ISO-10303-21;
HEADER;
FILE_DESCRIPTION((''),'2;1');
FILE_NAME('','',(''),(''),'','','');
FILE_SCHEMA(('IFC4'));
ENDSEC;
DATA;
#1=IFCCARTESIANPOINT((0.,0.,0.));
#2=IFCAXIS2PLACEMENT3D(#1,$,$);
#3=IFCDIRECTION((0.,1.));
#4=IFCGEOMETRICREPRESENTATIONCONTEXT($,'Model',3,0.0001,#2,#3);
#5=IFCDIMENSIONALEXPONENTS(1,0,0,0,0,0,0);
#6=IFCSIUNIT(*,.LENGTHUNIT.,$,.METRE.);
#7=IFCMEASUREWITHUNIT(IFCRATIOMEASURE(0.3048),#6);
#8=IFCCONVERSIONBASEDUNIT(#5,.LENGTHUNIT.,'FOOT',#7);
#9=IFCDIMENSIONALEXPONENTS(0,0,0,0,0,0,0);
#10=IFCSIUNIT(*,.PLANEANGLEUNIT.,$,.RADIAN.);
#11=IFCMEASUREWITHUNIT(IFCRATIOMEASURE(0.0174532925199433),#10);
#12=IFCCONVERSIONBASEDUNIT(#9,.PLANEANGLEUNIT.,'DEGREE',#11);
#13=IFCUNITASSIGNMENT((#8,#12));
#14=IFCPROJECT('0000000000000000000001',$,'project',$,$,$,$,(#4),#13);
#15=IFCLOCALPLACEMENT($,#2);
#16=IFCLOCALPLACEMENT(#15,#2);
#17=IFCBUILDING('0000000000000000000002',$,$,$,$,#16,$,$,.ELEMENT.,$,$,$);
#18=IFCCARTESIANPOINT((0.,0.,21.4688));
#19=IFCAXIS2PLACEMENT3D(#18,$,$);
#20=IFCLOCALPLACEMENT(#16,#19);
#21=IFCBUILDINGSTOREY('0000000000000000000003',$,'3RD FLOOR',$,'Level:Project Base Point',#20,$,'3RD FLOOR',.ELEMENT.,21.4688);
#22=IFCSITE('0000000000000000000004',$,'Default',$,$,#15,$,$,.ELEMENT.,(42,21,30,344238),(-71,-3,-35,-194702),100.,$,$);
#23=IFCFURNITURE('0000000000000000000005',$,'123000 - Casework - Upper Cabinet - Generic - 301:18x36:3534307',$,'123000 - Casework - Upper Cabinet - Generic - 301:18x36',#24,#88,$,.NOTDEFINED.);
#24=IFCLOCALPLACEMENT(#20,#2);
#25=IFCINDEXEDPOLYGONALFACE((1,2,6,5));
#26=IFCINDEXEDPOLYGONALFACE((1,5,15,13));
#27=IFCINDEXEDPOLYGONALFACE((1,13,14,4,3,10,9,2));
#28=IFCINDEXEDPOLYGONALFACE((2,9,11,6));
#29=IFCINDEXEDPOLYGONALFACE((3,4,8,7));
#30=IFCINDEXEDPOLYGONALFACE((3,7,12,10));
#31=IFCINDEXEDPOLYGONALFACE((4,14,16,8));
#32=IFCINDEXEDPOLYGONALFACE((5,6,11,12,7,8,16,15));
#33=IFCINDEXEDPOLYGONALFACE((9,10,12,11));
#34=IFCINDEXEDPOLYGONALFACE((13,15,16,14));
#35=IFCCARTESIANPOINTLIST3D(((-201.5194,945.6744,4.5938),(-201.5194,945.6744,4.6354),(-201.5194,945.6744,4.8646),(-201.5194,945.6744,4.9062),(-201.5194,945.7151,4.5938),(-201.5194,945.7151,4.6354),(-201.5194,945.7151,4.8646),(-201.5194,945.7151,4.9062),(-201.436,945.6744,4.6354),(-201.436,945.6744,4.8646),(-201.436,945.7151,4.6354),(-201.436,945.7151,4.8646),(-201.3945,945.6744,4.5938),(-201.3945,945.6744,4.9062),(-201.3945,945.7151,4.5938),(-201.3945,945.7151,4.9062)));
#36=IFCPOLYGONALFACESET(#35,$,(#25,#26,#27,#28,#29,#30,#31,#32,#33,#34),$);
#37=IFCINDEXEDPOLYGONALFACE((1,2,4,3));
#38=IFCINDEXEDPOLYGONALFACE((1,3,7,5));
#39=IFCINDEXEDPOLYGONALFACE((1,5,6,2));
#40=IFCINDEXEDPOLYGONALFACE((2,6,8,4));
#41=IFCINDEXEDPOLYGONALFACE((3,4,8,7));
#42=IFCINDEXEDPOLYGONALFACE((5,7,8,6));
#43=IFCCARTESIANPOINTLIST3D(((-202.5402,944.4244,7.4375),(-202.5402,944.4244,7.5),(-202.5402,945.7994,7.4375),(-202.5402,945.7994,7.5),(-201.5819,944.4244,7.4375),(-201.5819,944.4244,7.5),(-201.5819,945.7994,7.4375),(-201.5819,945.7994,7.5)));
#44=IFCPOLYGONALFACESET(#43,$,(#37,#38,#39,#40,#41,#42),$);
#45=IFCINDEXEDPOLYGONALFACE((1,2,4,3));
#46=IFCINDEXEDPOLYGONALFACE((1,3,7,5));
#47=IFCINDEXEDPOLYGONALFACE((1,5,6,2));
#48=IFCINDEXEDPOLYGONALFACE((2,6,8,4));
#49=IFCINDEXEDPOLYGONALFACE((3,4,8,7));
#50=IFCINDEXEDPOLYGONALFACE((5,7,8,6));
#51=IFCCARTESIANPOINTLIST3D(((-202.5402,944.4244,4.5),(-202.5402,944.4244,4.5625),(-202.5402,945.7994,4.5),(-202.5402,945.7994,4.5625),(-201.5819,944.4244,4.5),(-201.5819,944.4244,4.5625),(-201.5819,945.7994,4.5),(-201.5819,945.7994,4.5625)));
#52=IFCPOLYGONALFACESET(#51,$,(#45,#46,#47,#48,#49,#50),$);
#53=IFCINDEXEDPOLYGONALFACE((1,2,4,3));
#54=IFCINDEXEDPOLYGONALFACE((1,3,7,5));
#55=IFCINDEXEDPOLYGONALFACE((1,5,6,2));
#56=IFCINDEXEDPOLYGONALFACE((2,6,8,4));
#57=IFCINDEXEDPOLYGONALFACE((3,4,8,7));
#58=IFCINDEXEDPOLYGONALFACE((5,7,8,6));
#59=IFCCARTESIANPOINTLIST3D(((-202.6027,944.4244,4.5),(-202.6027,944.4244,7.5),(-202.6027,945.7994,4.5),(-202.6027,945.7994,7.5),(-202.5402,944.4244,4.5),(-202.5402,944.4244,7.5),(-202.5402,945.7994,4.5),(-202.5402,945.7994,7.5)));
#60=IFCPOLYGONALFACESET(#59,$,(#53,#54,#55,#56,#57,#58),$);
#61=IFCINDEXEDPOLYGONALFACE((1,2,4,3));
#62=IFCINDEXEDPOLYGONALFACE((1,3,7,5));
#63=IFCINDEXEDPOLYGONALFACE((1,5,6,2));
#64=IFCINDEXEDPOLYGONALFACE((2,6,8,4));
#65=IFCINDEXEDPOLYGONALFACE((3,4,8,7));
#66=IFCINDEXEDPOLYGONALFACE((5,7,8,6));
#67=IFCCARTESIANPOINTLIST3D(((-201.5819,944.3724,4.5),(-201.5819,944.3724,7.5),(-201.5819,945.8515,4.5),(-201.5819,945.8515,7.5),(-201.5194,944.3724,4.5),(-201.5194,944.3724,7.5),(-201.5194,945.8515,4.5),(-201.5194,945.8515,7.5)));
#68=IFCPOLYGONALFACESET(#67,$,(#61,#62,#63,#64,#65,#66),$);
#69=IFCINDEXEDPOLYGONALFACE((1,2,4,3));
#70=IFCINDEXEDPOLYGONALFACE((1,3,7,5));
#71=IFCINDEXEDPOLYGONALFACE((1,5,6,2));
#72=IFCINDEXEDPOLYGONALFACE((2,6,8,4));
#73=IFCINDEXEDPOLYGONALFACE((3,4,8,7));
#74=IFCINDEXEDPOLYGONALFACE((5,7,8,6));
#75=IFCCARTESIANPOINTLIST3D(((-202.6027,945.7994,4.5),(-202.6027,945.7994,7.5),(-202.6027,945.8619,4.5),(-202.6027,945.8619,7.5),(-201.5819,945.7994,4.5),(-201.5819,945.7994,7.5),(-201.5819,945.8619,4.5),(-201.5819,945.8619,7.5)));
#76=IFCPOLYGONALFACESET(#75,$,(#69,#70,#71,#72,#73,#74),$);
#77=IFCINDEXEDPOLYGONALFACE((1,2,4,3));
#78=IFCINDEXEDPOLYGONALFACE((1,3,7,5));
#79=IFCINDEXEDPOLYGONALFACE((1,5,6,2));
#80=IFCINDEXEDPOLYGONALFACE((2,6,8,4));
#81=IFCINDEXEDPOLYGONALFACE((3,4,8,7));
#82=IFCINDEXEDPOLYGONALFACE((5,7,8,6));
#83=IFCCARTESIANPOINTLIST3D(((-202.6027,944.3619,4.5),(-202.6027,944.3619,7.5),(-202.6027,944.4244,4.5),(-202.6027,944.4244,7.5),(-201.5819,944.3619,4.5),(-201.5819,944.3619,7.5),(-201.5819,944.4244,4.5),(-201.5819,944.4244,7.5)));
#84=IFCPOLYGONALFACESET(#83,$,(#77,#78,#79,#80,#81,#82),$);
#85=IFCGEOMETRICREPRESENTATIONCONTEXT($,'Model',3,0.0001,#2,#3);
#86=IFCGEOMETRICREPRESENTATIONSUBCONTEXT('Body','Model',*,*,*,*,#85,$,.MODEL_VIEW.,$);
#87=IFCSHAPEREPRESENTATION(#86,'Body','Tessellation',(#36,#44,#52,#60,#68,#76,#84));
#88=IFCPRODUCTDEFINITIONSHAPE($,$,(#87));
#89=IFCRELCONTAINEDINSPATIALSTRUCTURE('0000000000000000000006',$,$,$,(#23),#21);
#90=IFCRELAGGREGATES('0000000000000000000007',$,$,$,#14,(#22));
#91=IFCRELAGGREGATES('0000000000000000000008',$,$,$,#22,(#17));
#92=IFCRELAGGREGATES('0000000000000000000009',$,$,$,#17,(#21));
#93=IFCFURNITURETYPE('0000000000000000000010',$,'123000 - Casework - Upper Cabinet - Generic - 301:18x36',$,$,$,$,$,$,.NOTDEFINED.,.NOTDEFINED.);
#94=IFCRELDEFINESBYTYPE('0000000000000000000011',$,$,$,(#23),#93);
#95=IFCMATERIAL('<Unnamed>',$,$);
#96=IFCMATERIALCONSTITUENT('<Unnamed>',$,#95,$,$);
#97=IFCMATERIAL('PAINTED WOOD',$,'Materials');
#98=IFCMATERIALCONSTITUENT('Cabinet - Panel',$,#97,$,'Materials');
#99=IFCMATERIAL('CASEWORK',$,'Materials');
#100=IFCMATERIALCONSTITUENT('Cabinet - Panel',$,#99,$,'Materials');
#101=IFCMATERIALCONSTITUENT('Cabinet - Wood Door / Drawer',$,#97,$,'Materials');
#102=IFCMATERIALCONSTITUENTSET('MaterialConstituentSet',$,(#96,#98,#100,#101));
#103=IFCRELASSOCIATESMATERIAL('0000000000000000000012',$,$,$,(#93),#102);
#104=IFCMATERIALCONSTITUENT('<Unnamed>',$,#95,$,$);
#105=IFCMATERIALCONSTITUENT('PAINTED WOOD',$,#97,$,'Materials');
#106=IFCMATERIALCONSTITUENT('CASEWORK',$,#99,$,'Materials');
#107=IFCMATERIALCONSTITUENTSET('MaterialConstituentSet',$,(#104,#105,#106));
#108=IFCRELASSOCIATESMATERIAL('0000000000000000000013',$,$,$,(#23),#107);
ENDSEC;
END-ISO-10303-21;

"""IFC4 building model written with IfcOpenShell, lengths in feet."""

from ifc_helpers import new_model, entity, si_unit, converted_unit, direction, frame, frame_2d, origin, origin_2d_with_axis, place, context, subcontext, project, spatial, polyline, rectangle, outline, extrude, source, transform, mapped, material, constituent, constituent_set, type_object, type_shapes, element, save


model = new_model("IFC4")

# Units and contexts
model_context_1 = context("Model", 3, precision=0.0001, world=origin(), true_north=direction((0.0, 1.0)))
model_context_2 = context("Model", 3, precision=0.0001, world=origin(), true_north=direction((0.0, 1.0)))
body_context = subcontext(model_context_2, "Body", "Model", "MODEL_VIEW")
ifc_project = project(units=[converted_unit("LENGTHUNIT", "FOOT", entity("IfcRatioMeasure", 0.3048), si_unit("LENGTHUNIT", "METRE"), dimensions=[1, 0, 0, 0, 0, 0, 0]), converted_unit("PLANEANGLEUNIT", "DEGREE", entity("IfcRatioMeasure", 0.0174532925199433), si_unit("PLANEANGLEUNIT", "RADIAN"), dimensions=[0, 0, 0, 0, 0, 0, 0])], contexts=[model_context_1])

# Site, building, storey
site_placement = place(None, origin())
site = spatial("IfcSite", under=ifc_project, at=site_placement, Name="Default", CompositionType="ELEMENT", RefLatitude=(42, 21, 30, 344238), RefLongitude=(-71, -3, -35, -194702), RefElevation=100.0)
building_placement = place(site_placement, origin())
building = spatial("IfcBuilding", under=site, at=building_placement, CompositionType="ELEMENT")
storey_placement = place(building_placement, frame((0.0, 0.0, 21.4688)))
storey = spatial("IfcBuildingStorey", under=building, at=storey_placement, Name="3RD FLOOR", ObjectType="Level:Project Base Point", LongName="3RD FLOOR", CompositionType="ELEMENT", Elevation=21.4688)

# Furniture
ifc_material_1 = material(Name="CASEWORK", Category="Materials")
ifc_material_2 = material(Name="PAINTED WOOD", Category="Materials")
ifc_material_3 = material(Name="<Unnamed>")
ifc_constituent_1 = constituent(ifc_material_3, Name="<Unnamed>")
ifc_constituent_2 = constituent(ifc_material_2, Name="PAINTED WOOD", Category="Materials")
ifc_constituent_3 = constituent(ifc_material_1, Name="CASEWORK", Category="Materials")
ifc_constituent_set_1 = constituent_set(constituents=[ifc_constituent_1, ifc_constituent_2, ifc_constituent_3], Name="MaterialConstituentSet")
ifc_constituent_4 = constituent(ifc_material_3, Name="<Unnamed>")
ifc_constituent_5 = constituent(ifc_material_2, Name="Cabinet - Panel", Category="Materials")
ifc_constituent_6 = constituent(ifc_material_1, Name="Cabinet - Panel", Category="Materials")
ifc_constituent_7 = constituent(ifc_material_2, Name="Cabinet - Wood Door / Drawer", Category="Materials")
ifc_constituent_set_2 = constituent_set(constituents=[ifc_constituent_4, ifc_constituent_5, ifc_constituent_6, ifc_constituent_7], Name="MaterialConstituentSet")
furniture_type_1 = type_object("IfcFurnitureType", Name="123000 - Casework - Upper Cabinet - Generic - 301:18x36", AssemblyPlace="NOTDEFINED", PredefinedType="NOTDEFINED", material=ifc_constituent_set_2)
shared_shape_1 = source(origin(), body_context, "Body", "SweptSolid", [
    extrude(outline(polyline([(-0.0521, -0.1146), (-0.0521, -0.1562), (0.0729, -0.1562), (0.0729, 0.1562), (-0.0521, 0.1562), (-0.0521, 0.1146), (0.0313, 0.1146), (0.0313, -0.1146), (-0.0521, -0.1146)])), frame((0.1468, 1.1354, 0.25), z_axis=(-1.0, 0.0, 0.0), x_axis=(0.0, 1.0, 0.0)), (0.0, 0.0, -1.0), 0.0407),
    extrude(rectangle(XDim=0.9583, YDim=1.375, at=frame_2d((0.0, 0.0), x_axis=(1.0, 0.0))), frame((0.75, 0.5417, 2.9375), z_axis=(0.0, 0.0, 1.0), x_axis=(0.0, 1.0, 0.0)), (0.0, 0.0, 1.0), 0.0625),
    extrude(rectangle(XDim=0.9583, YDim=1.375, at=frame_2d((0.0, 0.0), x_axis=(1.0, 0.0))), frame((0.75, 0.5417, 0.0), z_axis=(0.0, 0.0, 1.0), x_axis=(0.0, 1.0, 0.0)), (0.0, 0.0, 1.0), 0.0625),
    extrude(rectangle(XDim=1.375, YDim=0.0625, at=origin_2d_with_axis()), frame((0.75, 0.0313, 0.0), z_axis=(0.0, 0.0, 1.0), x_axis=(-1.0, 0.0, 0.0)), (0.0, 0.0, 1.0), 3.0),
    extrude(rectangle(XDim=1.4792, YDim=0.0625, at=origin_2d_with_axis()), frame((0.75, 1.0521, 0.0)), (0.0, 0.0, 1.0), 3.0),
    extrude(rectangle(XDim=1.0208, YDim=0.0625, at=origin_2d_with_axis()), frame((0.0312, 0.5104, 0.0), z_axis=(0.0, 0.0, 1.0), x_axis=(0.0, 1.0, 0.0)), (0.0, 0.0, 1.0), 3.0),
    extrude(rectangle(XDim=1.0208, YDim=0.0625, at=origin_2d_with_axis()), frame((1.4688, 0.5104, 0.0), z_axis=(0.0, 0.0, 1.0), x_axis=(0.0, 1.0, 0.0)), (0.0, 0.0, 1.0), 3.0),
])
type_shapes(furniture_type_1, [shared_shape_1])
furniture_1_placement = place(storey_placement, frame((-202.6027, 945.8619, 4.5), z_axis=(0.0, 0.0, 1.0), x_axis=(0.0, -1.0, 0.0)))
element("IfcFurniture", 1, at=furniture_1_placement, inside=storey, type_object=furniture_type_1, material=ifc_constituent_set_1, Name="123000 - Casework - Upper Cabinet - Generic - 301:18x36:3534307", ObjectType="123000 - Casework - Upper Cabinet - Generic - 301:18x36", PredefinedType="NOTDEFINED", context=body_context, shape_type="MappedRepresentation", body=[
    mapped(shared_shape_1, transform((0.0, 0.0, 0.0), scale=1.0)),
])

save(model, "model.ifc")
